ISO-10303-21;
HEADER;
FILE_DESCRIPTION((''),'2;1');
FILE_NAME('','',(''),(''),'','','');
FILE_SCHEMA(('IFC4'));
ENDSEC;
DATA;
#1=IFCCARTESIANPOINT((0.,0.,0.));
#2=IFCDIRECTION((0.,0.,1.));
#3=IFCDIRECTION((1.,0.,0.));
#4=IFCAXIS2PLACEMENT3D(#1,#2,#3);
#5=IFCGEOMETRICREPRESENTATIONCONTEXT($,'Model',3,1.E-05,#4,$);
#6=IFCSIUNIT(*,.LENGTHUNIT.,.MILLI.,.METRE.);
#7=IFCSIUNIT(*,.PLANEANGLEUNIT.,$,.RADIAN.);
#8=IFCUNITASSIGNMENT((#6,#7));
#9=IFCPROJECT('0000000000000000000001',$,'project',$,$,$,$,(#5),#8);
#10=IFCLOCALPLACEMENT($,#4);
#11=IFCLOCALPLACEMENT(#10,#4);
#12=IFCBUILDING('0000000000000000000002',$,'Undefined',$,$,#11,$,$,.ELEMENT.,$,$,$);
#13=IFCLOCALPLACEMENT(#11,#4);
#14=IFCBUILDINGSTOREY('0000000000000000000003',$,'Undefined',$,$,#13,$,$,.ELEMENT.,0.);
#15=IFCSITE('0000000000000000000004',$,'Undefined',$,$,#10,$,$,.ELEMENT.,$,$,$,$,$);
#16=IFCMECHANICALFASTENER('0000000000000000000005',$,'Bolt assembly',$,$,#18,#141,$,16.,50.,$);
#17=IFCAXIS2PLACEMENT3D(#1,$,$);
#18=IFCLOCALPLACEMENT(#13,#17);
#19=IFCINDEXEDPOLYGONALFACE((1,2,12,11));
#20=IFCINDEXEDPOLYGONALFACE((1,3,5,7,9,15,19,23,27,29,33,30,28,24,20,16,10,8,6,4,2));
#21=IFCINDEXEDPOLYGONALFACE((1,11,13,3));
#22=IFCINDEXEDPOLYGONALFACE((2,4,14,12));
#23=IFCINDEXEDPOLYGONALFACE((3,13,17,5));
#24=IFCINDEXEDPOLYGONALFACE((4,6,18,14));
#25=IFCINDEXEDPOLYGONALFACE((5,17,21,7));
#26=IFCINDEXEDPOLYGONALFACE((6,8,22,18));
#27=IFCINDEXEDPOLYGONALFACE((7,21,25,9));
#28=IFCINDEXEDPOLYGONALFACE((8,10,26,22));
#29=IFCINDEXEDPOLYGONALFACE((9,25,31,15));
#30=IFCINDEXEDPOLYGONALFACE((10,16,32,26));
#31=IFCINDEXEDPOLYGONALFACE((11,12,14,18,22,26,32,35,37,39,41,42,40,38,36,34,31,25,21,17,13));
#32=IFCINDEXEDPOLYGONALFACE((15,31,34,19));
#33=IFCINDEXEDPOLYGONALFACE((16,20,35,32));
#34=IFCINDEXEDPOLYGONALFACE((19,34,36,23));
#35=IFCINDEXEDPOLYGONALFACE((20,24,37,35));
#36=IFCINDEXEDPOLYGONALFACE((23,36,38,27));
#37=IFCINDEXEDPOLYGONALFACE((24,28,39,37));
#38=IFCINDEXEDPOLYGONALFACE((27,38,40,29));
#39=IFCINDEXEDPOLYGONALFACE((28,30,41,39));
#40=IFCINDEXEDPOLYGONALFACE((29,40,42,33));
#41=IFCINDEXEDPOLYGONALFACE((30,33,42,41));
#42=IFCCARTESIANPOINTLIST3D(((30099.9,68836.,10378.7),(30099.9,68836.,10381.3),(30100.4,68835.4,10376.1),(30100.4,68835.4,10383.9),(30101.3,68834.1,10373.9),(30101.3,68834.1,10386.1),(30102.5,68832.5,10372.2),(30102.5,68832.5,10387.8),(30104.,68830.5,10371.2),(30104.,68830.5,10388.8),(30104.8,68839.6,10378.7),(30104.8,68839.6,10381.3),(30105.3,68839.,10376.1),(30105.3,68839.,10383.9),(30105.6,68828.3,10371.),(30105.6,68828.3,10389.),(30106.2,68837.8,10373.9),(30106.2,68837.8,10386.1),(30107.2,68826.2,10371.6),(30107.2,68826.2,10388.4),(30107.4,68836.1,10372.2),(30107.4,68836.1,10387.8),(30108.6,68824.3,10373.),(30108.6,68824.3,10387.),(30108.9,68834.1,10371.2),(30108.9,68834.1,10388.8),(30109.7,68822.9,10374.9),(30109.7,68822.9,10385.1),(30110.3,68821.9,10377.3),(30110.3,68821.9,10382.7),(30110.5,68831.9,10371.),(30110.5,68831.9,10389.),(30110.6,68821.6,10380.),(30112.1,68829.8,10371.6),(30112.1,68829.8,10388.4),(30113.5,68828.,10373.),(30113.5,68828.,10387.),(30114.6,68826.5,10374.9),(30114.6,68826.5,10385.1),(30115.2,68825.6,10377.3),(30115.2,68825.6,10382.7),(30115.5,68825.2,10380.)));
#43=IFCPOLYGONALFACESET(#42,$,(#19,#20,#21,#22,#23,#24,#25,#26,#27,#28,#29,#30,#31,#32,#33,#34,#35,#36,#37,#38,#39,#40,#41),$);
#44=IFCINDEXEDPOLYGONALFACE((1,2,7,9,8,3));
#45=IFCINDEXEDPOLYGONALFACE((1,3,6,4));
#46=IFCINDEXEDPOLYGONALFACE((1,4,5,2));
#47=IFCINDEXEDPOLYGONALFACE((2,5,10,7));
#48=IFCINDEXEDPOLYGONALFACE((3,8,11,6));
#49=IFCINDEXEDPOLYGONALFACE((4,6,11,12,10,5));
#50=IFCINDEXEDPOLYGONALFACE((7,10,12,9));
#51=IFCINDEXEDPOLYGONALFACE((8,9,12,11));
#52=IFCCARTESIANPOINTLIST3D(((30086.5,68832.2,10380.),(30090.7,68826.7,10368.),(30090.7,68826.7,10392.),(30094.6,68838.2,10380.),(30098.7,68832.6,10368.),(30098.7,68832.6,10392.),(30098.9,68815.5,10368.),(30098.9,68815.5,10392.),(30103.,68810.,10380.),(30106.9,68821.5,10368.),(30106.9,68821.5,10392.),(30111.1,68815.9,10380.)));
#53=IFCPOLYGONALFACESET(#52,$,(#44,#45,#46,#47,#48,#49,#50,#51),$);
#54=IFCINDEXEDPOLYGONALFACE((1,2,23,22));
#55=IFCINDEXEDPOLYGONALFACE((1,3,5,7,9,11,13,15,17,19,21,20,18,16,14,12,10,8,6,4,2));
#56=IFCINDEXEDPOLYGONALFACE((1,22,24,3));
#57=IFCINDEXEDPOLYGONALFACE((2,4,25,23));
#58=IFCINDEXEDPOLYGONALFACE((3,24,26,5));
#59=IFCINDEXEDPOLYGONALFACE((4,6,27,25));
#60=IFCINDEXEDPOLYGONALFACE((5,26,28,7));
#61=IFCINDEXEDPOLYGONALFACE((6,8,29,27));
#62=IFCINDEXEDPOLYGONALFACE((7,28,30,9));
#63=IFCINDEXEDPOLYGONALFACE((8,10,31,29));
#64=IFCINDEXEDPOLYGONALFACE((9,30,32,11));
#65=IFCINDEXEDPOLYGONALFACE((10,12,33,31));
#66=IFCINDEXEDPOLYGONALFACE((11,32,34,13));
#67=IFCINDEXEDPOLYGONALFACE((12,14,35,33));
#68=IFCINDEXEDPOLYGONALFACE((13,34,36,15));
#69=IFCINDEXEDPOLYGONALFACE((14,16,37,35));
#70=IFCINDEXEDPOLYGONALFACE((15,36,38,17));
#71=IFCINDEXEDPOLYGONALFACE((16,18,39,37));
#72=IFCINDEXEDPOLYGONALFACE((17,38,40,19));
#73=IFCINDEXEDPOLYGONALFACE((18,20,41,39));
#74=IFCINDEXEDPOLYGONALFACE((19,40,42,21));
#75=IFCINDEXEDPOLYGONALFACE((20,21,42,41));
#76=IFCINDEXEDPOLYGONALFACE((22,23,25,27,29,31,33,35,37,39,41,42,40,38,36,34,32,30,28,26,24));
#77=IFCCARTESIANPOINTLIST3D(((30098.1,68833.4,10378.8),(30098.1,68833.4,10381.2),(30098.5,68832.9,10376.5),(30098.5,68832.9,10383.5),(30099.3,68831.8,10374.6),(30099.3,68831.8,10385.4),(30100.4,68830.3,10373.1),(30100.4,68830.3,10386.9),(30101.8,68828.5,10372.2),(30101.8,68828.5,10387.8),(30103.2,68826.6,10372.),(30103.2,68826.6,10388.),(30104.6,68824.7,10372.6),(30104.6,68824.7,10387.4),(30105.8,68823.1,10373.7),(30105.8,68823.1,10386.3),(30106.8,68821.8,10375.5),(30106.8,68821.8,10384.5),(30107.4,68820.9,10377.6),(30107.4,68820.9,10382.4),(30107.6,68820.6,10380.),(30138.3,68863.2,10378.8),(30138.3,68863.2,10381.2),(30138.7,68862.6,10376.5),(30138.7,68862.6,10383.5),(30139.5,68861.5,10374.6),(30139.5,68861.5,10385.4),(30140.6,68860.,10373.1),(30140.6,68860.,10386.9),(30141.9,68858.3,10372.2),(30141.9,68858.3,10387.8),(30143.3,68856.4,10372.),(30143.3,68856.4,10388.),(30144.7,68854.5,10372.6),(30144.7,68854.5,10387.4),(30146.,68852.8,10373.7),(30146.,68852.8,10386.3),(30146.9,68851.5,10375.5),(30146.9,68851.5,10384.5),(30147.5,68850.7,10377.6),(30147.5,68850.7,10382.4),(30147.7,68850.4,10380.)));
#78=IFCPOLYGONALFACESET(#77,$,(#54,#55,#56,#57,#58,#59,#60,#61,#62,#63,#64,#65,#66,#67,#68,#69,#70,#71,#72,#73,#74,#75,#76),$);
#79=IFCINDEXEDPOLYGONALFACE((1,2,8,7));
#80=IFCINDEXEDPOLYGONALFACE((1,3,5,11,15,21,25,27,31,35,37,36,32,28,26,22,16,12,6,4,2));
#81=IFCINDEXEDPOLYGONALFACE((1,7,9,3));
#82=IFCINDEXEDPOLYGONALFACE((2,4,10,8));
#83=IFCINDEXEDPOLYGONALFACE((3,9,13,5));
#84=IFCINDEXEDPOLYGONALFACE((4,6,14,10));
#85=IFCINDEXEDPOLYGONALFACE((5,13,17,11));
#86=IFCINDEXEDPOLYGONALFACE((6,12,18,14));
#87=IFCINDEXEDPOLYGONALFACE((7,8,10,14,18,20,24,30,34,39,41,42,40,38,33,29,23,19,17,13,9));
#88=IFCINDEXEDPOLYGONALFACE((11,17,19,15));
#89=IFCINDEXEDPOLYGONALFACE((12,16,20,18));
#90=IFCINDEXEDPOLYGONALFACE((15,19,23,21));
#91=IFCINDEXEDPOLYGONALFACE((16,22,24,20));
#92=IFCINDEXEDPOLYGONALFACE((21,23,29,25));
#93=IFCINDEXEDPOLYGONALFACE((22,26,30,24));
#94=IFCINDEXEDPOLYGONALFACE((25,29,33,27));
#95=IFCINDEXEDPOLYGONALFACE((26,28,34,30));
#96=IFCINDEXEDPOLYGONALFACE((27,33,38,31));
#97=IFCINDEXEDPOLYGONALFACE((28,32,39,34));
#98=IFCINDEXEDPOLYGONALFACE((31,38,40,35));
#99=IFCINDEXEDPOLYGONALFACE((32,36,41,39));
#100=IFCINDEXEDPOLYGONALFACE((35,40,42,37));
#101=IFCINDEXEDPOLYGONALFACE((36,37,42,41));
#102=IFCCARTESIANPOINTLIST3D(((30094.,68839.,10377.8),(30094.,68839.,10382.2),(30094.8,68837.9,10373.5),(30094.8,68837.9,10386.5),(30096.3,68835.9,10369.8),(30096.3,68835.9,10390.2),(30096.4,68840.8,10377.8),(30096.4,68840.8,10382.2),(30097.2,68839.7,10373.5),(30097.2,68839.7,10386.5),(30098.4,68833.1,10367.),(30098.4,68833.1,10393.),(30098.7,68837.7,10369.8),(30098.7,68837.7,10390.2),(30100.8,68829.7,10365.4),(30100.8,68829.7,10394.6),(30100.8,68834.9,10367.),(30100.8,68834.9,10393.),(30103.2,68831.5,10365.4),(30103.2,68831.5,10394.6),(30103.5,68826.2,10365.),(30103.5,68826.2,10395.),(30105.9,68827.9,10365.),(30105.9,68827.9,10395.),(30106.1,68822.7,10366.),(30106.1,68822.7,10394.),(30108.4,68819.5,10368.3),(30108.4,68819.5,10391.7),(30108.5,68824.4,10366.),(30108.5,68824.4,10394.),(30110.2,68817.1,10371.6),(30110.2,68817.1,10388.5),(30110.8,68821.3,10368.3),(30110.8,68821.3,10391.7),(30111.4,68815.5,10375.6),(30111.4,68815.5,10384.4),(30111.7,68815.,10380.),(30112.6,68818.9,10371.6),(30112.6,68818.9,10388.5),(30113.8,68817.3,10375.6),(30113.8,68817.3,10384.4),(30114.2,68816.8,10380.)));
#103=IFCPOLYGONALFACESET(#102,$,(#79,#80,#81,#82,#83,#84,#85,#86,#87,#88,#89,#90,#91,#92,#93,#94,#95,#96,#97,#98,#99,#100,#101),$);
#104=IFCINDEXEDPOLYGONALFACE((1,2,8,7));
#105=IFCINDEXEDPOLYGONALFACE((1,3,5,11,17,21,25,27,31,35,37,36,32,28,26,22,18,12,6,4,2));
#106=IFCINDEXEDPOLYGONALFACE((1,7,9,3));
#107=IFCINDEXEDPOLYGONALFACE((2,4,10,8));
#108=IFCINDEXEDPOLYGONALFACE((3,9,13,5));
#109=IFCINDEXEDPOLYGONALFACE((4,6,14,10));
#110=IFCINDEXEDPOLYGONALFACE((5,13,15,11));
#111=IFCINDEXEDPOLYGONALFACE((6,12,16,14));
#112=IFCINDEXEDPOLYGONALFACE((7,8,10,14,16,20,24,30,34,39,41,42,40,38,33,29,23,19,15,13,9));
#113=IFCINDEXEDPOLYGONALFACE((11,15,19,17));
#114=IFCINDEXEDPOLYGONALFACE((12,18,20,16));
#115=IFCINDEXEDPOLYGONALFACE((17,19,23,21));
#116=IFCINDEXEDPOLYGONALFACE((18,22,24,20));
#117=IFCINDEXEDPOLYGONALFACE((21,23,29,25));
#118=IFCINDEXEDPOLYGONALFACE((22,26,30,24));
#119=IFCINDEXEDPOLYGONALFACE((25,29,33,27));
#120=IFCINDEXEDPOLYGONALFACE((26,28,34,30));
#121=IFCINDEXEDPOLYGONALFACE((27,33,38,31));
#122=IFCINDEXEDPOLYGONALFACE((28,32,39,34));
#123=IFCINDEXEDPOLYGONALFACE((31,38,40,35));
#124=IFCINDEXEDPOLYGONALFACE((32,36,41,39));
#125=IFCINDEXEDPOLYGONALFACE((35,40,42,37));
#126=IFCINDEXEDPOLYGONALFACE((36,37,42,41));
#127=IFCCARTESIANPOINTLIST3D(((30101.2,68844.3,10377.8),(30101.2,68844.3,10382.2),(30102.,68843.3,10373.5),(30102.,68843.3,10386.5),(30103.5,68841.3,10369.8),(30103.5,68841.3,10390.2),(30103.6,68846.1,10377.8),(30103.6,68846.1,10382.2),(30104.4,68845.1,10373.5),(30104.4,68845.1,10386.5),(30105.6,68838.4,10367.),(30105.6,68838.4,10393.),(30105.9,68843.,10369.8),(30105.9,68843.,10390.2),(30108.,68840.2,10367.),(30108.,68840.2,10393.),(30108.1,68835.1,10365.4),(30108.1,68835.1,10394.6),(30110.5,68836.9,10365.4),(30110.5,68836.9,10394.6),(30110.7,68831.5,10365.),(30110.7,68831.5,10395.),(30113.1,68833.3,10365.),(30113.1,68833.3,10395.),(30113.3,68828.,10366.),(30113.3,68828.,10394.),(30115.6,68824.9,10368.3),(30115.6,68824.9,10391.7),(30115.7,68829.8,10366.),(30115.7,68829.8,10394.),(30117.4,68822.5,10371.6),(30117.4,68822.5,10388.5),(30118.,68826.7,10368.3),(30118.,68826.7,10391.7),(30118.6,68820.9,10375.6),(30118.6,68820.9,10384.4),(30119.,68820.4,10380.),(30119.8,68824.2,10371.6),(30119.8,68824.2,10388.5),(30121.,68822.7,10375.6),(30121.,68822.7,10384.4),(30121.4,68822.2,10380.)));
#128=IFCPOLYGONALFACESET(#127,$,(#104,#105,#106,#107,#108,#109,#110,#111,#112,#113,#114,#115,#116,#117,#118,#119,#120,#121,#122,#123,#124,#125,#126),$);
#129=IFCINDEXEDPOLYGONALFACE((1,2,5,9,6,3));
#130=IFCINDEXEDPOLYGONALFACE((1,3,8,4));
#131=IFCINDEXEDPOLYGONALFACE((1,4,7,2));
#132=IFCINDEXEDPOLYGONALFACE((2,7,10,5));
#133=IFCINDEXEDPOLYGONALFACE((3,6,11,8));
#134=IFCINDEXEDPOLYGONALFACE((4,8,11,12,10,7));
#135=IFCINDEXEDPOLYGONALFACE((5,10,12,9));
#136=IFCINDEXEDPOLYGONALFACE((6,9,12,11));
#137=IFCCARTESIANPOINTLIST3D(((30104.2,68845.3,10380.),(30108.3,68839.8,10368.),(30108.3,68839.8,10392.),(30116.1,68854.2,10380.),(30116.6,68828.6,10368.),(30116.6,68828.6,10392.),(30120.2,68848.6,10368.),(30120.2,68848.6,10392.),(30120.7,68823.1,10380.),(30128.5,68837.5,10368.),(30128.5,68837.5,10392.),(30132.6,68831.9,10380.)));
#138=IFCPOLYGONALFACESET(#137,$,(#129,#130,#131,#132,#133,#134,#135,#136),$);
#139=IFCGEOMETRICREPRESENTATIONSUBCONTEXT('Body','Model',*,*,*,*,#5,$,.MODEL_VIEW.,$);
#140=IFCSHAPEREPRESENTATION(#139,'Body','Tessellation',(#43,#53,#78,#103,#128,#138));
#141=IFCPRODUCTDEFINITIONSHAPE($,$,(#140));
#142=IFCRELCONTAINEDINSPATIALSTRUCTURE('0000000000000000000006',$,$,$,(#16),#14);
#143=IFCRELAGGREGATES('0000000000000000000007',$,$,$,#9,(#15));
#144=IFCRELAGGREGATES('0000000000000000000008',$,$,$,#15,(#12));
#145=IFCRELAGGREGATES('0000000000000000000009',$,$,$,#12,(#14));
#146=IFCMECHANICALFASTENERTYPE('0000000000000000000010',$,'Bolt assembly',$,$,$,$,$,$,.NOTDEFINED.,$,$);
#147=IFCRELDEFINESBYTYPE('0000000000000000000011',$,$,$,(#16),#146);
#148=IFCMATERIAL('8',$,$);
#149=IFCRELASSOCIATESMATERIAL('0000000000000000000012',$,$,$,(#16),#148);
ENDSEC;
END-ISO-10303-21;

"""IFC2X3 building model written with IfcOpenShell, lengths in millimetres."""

from ifc_helpers import new_model, si_unit, frame, origin_with_axes, origin_2d_with_axis, place, context, subcontext, project, spatial, polyline, circle, outline, extrude, source, transform, mapped, material, type_object, element, save


model = new_model("IFC2X3")

# Units and contexts
model_context = context("Model", 3, precision=1e-05, world=origin_with_axes())
body_context = subcontext(model_context, "Body", "Model", "MODEL_VIEW")
ifc_project = project(units=[si_unit("LENGTHUNIT", "METRE", prefix="MILLI"), si_unit("PLANEANGLEUNIT", "RADIAN")], contexts=[model_context])

# Site, building, storey
site_placement = place(None, origin_with_axes())
site = spatial("IfcSite", under=ifc_project, at=site_placement, Name="Undefined", CompositionType="ELEMENT")
building_placement = place(site_placement, origin_with_axes())
building = spatial("IfcBuilding", under=site, at=building_placement, Name="Undefined", CompositionType="ELEMENT")
storey_placement = place(building_placement, origin_with_axes())
storey = spatial("IfcBuildingStorey", under=building, at=storey_placement, Name="Undefined", CompositionType="ELEMENT", Elevation=0.0)

# Shared definitions
ifc_material_1 = material(Name="8")
mechanical_fastener_type = type_object("IfcMechanicalFastenerType", Name="Bolt assembly")

# Mechanical fastener
shared_shape_1 = source(origin_with_axes(), body_context, "Body", "SweptSolid", [
    extrude(circle(Radius=9.0, at=origin_2d_with_axis()), frame((0.0, 11.5, 0.0), z_axis=(0.0, 1.0, 0.0), x_axis=(1.0, 0.0, 0.0)), (0.0, 0.0, 1.0), 6.1),
    extrude(outline(polyline([(13.9, 0.0), (6.9, 12.0), (-6.9, 12.0), (-13.9, 0.0), (-6.9, -12.0), (6.9, -12.0), (13.9, 0.0)])), frame((0.0, -1.5, 0.0), z_axis=(0.0, 1.0, 0.0), x_axis=(1.0, 0.0, 0.0)), (0.0, 0.0, 1.0), 10.0),
    extrude(circle(Radius=8.0, at=origin_2d_with_axis()), frame((0.0, 8.5, 0.0), z_axis=(0.0, 1.0, 0.0), x_axis=(1.0, 0.0, 0.0)), (0.0, 0.0, 1.0), 50.0),
    extrude(circle(Radius=15.0, at=origin_2d_with_axis()), frame((0.0, 8.5, 0.0), z_axis=(0.0, 1.0, 0.0), x_axis=(1.0, 0.0, 0.0)), (0.0, 0.0, 1.0), 3.0),
    extrude(circle(Radius=15.0, at=origin_2d_with_axis()), frame((0.0, 17.5, 0.0), z_axis=(0.0, 1.0, 0.0), x_axis=(1.0, 0.0, 0.0)), (0.0, 0.0, 1.0), 3.0),
    extrude(outline(polyline([(13.9, 0.0), (6.9, 12.0), (-6.9, 12.0), (-13.9, 0.0), (-6.9, -12.0), (6.9, -12.0), (13.9, 0.0)])), frame((0.0, 20.5, 0.0), z_axis=(0.0, 1.0, 0.0), x_axis=(1.0, 0.0, 0.0)), (0.0, 0.0, 1.0), 14.8),
])
for number, where, z_axis, x_axis, name in (
    (1, (30096.0, 68822.0, 10380.0), (0.0, 0.0, 1.0), (0.595463, -0.803383, 0.0), "Bolt assembly"),
):
    element("IfcMechanicalFastener", number, at=place(storey_placement, frame(where, z_axis=z_axis, x_axis=x_axis)), inside=storey, type_object=mechanical_fastener_type, material=ifc_material_1, Name=name, NominalDiameter=16.0, NominalLength=50.0, context=body_context, shape_type="MappedRepresentation", body=[
        mapped(shared_shape_1, transform((0.0, 0.0, 0.0))),
    ])

save(model, "model.ifc")
